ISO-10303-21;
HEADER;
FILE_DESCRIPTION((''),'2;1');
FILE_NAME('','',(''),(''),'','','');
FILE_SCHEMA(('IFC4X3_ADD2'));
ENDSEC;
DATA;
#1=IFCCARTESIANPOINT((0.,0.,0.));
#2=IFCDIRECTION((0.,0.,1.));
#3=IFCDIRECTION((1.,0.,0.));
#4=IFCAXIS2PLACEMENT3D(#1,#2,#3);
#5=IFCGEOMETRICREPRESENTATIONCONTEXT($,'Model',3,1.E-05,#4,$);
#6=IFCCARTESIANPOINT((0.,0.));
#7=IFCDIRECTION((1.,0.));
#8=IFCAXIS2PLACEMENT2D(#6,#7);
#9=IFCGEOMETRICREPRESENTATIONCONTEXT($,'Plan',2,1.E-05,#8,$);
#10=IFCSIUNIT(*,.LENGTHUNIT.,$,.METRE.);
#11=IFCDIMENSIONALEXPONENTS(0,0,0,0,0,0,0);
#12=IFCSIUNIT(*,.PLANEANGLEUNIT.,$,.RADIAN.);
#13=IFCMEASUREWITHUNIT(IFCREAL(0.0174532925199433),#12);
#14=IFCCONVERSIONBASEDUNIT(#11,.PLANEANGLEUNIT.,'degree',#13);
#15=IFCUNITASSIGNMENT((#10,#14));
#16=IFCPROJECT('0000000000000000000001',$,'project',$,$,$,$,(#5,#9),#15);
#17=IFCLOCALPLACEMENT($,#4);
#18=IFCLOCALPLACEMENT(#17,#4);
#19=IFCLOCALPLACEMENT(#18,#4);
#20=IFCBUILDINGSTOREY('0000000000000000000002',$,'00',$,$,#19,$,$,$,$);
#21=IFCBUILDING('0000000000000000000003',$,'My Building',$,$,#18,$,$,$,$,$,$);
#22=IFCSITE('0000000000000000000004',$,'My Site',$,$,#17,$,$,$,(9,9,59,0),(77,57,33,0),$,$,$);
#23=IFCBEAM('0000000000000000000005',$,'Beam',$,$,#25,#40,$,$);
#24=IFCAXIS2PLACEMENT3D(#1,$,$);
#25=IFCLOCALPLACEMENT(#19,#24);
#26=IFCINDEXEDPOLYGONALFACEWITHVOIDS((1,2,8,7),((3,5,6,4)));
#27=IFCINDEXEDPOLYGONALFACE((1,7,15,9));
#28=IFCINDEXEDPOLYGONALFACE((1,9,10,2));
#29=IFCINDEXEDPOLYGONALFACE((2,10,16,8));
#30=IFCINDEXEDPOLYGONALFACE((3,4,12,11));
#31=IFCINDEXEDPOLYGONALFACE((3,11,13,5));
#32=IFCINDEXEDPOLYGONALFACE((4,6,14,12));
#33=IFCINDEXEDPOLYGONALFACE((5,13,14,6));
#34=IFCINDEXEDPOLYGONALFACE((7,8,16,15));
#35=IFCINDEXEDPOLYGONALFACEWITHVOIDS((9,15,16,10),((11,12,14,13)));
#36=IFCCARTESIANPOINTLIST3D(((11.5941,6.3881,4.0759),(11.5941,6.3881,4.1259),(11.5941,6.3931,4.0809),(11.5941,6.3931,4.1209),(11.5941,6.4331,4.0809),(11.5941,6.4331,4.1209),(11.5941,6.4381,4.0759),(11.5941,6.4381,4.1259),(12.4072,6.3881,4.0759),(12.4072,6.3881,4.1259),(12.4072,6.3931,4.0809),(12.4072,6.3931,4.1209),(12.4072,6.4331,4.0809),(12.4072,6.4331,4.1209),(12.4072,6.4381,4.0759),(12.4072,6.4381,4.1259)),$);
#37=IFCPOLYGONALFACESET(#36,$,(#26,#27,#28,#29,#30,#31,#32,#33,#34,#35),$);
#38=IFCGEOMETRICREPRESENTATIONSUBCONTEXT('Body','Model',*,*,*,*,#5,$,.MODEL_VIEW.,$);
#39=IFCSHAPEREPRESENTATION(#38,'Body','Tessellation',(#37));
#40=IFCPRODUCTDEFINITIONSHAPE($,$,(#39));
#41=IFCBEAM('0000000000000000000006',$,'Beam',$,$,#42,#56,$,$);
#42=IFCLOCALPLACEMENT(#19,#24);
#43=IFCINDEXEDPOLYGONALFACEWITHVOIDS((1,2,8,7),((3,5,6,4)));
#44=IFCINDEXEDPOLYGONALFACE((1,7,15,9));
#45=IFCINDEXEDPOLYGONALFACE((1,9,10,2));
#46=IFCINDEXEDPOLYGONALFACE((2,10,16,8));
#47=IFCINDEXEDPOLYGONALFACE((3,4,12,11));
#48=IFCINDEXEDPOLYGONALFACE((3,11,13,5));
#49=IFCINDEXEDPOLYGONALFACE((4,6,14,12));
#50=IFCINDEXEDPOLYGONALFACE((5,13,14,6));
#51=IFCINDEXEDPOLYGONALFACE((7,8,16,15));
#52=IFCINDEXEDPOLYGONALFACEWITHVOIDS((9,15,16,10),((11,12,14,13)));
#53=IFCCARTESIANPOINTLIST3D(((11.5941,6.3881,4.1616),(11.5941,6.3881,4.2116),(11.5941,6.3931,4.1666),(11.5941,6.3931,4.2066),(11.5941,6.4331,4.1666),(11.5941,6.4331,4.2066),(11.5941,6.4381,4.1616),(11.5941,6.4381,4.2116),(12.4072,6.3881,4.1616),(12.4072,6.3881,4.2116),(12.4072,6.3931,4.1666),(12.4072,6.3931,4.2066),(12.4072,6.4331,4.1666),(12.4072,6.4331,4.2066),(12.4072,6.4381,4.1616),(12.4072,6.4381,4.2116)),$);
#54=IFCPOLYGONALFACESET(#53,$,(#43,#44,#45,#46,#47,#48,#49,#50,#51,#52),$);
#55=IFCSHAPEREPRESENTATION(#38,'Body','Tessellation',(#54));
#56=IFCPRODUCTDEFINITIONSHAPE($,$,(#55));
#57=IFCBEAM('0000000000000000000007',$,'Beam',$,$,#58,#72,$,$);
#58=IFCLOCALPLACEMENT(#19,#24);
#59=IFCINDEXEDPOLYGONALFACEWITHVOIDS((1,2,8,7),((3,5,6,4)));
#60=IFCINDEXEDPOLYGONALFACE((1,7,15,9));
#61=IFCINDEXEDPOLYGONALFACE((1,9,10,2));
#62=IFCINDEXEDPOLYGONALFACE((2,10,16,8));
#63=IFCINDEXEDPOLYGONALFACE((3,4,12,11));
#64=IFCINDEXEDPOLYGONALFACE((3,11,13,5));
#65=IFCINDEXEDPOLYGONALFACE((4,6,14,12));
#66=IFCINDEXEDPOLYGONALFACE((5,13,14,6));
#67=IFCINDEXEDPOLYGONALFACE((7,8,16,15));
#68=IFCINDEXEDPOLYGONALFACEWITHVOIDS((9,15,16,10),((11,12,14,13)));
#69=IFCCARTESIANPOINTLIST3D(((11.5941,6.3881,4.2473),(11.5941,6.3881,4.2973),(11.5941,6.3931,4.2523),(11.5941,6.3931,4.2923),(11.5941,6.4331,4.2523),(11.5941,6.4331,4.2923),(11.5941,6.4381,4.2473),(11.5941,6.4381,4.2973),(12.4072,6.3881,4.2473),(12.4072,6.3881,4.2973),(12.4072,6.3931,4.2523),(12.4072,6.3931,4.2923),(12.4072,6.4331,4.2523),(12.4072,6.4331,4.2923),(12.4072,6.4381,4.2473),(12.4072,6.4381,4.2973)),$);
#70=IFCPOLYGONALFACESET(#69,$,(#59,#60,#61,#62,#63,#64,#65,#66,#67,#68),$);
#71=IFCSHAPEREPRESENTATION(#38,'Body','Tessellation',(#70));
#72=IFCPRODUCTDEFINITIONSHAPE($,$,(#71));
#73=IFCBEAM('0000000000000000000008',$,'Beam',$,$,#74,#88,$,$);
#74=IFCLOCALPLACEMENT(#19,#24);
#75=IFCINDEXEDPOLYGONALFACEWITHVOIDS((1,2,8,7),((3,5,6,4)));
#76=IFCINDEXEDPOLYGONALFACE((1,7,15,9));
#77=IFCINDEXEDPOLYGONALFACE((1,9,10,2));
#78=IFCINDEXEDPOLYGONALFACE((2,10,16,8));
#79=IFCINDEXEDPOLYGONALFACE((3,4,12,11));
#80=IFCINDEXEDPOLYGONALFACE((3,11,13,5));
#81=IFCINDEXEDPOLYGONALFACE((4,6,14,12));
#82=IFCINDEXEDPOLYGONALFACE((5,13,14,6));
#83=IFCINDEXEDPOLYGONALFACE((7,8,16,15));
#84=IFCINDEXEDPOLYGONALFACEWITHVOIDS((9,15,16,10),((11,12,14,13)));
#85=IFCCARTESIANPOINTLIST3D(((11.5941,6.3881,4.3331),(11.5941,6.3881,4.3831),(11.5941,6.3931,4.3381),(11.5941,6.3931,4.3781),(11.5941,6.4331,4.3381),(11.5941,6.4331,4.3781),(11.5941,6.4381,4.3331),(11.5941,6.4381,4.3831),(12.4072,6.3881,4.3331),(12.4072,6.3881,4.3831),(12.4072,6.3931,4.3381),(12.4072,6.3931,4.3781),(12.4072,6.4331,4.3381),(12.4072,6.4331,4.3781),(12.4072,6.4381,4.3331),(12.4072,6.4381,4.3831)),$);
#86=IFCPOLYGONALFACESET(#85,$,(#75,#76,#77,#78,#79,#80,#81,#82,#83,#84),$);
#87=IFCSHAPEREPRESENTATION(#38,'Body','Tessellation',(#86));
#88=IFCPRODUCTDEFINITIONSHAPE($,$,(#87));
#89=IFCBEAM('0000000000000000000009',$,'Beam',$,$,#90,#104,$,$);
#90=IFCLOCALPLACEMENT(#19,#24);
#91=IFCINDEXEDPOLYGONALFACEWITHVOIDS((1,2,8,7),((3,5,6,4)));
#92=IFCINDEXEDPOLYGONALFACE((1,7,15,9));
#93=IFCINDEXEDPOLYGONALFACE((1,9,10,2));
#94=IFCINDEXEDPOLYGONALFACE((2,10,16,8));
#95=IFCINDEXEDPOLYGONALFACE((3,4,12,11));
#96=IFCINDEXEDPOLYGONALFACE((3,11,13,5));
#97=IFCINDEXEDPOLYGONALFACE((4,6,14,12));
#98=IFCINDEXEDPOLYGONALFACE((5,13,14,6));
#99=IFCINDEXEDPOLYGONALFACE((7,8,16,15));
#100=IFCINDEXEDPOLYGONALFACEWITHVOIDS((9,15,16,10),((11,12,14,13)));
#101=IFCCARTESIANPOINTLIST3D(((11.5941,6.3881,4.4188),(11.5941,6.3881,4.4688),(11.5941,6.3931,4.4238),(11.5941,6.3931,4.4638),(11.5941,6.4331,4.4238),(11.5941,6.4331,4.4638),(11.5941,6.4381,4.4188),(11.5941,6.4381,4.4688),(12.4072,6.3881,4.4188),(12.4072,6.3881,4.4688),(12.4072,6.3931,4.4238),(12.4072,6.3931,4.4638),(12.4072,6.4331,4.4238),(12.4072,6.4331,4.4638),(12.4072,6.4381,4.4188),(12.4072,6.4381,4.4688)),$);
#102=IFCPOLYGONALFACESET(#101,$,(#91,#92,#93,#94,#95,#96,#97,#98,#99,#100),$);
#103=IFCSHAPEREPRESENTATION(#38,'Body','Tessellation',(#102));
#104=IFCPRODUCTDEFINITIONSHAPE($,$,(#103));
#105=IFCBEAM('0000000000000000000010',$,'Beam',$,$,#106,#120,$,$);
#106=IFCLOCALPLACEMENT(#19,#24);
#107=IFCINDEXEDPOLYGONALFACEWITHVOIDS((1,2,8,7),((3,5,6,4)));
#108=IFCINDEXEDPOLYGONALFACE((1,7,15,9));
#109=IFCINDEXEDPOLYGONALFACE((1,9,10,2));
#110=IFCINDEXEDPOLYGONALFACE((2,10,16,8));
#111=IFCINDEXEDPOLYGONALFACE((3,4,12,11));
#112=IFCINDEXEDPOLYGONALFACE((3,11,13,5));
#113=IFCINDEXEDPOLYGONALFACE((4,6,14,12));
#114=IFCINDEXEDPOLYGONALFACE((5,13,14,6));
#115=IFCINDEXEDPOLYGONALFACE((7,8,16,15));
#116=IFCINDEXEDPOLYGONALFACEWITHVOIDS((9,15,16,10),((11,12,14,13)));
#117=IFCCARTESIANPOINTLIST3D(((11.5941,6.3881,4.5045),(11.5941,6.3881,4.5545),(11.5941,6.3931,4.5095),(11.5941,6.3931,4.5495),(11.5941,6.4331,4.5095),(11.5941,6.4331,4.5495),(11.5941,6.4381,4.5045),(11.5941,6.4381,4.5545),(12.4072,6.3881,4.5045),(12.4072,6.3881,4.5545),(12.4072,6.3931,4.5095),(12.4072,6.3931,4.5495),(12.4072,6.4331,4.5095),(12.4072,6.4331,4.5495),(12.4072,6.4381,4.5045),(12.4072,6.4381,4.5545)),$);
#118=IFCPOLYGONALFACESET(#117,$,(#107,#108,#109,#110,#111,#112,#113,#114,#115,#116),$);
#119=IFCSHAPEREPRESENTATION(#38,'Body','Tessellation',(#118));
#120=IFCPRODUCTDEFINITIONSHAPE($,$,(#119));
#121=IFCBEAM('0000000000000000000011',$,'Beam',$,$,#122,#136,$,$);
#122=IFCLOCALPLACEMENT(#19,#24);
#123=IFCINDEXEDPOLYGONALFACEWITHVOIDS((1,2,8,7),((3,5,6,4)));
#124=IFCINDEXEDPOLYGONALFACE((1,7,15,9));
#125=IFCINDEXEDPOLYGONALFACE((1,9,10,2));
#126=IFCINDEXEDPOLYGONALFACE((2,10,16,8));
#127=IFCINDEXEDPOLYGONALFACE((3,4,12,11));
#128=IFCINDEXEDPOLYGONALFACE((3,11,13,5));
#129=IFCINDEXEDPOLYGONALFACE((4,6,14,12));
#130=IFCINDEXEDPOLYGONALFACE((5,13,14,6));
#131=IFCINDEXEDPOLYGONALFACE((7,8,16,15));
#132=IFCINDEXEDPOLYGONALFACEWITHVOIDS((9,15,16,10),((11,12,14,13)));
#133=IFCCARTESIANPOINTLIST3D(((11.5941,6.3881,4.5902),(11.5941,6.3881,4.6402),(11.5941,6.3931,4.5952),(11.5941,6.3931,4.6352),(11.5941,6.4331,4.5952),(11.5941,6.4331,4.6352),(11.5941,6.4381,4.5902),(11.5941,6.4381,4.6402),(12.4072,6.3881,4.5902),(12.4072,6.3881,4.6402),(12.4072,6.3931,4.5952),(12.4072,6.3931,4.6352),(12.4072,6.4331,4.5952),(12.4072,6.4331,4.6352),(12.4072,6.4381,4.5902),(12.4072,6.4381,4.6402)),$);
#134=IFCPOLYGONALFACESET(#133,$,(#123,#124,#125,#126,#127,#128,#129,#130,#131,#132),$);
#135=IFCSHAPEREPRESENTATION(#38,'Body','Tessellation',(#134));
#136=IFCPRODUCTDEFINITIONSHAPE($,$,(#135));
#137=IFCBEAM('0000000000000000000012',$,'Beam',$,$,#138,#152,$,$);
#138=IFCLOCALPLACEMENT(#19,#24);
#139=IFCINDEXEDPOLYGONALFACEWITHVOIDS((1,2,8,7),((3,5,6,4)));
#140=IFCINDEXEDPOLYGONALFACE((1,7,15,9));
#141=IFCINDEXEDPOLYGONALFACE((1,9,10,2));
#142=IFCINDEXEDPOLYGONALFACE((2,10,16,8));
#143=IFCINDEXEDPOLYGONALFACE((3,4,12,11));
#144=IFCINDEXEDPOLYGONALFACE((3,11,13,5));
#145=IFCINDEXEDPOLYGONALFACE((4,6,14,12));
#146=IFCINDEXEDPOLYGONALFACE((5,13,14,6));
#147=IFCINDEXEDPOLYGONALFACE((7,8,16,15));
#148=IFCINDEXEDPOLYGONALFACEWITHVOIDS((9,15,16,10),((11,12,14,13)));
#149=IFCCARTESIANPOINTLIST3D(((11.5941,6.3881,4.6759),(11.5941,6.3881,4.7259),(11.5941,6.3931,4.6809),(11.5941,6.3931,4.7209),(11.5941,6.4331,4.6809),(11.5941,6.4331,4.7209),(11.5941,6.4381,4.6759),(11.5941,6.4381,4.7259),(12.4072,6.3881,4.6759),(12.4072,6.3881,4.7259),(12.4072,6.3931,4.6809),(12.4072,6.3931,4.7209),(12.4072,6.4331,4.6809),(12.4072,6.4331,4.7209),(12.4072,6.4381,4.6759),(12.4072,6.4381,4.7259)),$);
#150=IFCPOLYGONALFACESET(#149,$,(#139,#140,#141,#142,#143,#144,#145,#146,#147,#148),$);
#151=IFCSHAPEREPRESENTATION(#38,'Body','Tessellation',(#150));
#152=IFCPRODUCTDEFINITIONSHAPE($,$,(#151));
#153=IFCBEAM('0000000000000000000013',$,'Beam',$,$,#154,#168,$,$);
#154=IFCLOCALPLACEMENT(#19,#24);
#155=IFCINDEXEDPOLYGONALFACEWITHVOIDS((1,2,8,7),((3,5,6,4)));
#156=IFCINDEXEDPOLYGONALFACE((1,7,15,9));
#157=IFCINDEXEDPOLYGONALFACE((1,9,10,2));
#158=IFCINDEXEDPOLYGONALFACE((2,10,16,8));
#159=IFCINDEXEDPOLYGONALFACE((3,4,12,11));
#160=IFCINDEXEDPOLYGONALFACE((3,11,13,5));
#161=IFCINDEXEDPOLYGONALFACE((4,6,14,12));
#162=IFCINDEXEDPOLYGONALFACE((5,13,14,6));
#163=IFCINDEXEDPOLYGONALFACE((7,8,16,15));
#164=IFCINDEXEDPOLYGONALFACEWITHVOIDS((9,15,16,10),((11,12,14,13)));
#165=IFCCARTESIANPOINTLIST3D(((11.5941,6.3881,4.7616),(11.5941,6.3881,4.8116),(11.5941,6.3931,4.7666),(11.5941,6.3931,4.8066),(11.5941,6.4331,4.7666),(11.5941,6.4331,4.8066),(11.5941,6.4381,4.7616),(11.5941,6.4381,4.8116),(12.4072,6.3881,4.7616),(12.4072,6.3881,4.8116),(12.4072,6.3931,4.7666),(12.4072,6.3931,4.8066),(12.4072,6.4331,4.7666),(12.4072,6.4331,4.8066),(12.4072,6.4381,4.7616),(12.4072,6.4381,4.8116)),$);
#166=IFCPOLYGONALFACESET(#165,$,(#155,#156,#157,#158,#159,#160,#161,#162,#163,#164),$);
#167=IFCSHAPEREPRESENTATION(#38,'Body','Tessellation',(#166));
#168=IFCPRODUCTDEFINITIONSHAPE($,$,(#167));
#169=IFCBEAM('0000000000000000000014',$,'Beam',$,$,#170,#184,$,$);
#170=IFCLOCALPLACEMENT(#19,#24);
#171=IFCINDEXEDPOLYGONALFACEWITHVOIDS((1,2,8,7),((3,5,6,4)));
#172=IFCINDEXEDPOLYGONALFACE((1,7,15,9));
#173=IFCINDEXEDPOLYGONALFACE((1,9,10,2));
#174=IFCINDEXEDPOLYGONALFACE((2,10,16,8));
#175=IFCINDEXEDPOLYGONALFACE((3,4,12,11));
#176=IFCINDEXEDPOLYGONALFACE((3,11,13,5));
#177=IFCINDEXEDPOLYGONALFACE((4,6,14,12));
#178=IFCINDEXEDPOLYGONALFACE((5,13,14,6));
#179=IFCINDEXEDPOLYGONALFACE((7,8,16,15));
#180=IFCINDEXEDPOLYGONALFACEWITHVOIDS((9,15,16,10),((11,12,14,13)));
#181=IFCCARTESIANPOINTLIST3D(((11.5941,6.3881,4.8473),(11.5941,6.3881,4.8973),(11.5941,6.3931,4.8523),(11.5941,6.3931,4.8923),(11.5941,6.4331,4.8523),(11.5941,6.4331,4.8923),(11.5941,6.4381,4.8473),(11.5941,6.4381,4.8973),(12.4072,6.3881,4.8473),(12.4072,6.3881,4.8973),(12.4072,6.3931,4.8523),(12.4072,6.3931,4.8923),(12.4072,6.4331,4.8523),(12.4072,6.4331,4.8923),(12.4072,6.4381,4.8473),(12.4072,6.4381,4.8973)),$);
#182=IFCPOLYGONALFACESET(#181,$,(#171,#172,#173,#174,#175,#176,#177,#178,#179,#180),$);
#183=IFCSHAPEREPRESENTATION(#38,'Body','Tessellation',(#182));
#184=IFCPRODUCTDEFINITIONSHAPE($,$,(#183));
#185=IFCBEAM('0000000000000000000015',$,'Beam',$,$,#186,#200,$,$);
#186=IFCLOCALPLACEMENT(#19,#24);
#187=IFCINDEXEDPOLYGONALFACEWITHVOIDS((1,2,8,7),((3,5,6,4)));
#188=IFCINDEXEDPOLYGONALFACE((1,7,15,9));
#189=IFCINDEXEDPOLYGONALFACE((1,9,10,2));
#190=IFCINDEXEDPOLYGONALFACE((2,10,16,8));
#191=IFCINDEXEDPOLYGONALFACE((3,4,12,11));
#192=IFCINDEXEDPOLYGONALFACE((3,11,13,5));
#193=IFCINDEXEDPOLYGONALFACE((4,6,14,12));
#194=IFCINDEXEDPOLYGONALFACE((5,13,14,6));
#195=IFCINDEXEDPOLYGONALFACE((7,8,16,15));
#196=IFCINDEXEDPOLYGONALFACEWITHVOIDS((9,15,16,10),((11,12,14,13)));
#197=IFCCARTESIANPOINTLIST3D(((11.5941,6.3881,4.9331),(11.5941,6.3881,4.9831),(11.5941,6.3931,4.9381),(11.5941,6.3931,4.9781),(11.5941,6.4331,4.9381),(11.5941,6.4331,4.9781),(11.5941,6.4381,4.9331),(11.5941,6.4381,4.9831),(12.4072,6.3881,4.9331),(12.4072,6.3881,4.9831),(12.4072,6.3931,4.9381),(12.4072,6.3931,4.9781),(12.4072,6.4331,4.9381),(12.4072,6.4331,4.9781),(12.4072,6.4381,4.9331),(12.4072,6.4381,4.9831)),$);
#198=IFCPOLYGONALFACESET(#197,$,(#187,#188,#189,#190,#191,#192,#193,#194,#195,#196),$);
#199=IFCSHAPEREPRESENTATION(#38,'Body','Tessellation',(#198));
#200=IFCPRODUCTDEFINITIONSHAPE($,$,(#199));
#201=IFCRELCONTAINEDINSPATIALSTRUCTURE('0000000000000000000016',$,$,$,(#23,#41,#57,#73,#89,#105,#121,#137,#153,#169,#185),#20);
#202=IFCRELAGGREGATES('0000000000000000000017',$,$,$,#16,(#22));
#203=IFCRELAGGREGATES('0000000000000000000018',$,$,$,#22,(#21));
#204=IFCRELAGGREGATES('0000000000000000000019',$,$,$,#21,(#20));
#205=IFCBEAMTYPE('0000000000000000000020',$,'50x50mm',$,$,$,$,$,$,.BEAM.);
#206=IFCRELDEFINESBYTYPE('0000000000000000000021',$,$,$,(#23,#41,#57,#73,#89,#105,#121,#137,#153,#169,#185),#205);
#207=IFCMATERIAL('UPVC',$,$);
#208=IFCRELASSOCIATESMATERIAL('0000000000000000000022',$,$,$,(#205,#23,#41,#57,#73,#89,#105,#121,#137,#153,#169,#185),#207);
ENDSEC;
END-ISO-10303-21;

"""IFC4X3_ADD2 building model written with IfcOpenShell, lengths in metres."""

from ifc_helpers import new_model, entity, si_unit, converted_unit, frame, origin_with_axes, origin_2d_with_axis, place, context, subcontext, project, spatial, hollow_rectangle, extrude, material, material_profile, profile_set, profile_usage, type_object, element, save


model = new_model("IFC4X3_ADD2")

# Units and contexts
model_context = context("Model", 3, precision=1e-05, world=origin_with_axes())
plan_context = context("Plan", 2, precision=1e-05, world=origin_2d_with_axis())
body_context = subcontext(model_context, "Body", "Model", "MODEL_VIEW")
ifc_project = project(units=[si_unit("LENGTHUNIT", "METRE"), converted_unit("PLANEANGLEUNIT", "degree", entity("IfcReal", 0.0174532925199433), si_unit("PLANEANGLEUNIT", "RADIAN"), dimensions=[0, 0, 0, 0, 0, 0, 0])], contexts=[model_context, plan_context])

# Site, building, storey
site_placement = place(None, origin_with_axes())
site = spatial("IfcSite", under=ifc_project, at=site_placement, Name="My Site", RefLatitude=(9, 9, 59, 0), RefLongitude=(77, 57, 33, 0))
building_placement = place(site_placement, origin_with_axes())
building = spatial("IfcBuilding", under=site, at=building_placement, Name="My Building")
storey_placement = place(building_placement, origin_with_axes())
storey = spatial("IfcBuildingStorey", under=building, at=storey_placement, Name="00")

# Shared definitions
ifc_material_1 = material(Name="UPVC")

# Beams
ifc_material_profile_1 = material_profile(ifc_material_1, hollow_rectangle(XDim=0.05, YDim=0.05, WallThickness=0.005))
ifc_profile_set_1 = profile_set([ifc_material_profile_1])
beam_type = type_object("IfcBeamType", Name="50x50mm", PredefinedType="BEAM", material=ifc_profile_set_1)
ifc_profile_usage_1 = profile_usage(ifc_profile_set_1, cardinal=5)
beam_1_placement = place(storey_placement, frame((11.5941, 6.4131, 4.1009), z_axis=(1.0, 0.0, 0.000001), x_axis=(0.0, 1.0, 0.0)))
element("IfcBeam", 1, at=beam_1_placement, inside=storey, type_object=beam_type, material=ifc_profile_usage_1, Name="Beam", context=body_context, shape_type="SweptSolid", body=[
    extrude(hollow_rectangle(XDim=0.05, YDim=0.05, WallThickness=0.005), origin_with_axes(), (0.0, 0.0, 1.0), 0.8131),
])
ifc_profile_usage_2 = profile_usage(ifc_profile_set_1, cardinal=5)
beam_2_placement = place(storey_placement, frame((11.5941, 6.4131, 4.1866), z_axis=(1.0, 0.0, 0.000001), x_axis=(0.0, 1.0, 0.0)))
element("IfcBeam", 2, at=beam_2_placement, inside=storey, type_object=beam_type, material=ifc_profile_usage_2, Name="Beam", context=body_context, shape_type="SweptSolid", body=[
    extrude(hollow_rectangle(XDim=0.05, YDim=0.05, WallThickness=0.005), origin_with_axes(), (0.0, 0.0, 1.0), 0.8131),
])
ifc_profile_usage_3 = profile_usage(ifc_profile_set_1, cardinal=5)
beam_3_placement = place(storey_placement, frame((11.5941, 6.4131, 4.2723), z_axis=(1.0, 0.0, 0.000001), x_axis=(0.0, 1.0, 0.0)))
element("IfcBeam", 3, at=beam_3_placement, inside=storey, type_object=beam_type, material=ifc_profile_usage_3, Name="Beam", context=body_context, shape_type="SweptSolid", body=[
    extrude(hollow_rectangle(XDim=0.05, YDim=0.05, WallThickness=0.005), origin_with_axes(), (0.0, 0.0, 1.0), 0.8131),
])
ifc_profile_usage_4 = profile_usage(ifc_profile_set_1, cardinal=5)
beam_4_placement = place(storey_placement, frame((11.5941, 6.4131, 4.3581), z_axis=(1.0, 0.0, 0.000001), x_axis=(0.0, 1.0, 0.0)))
element("IfcBeam", 4, at=beam_4_placement, inside=storey, type_object=beam_type, material=ifc_profile_usage_4, Name="Beam", context=body_context, shape_type="SweptSolid", body=[
    extrude(hollow_rectangle(XDim=0.05, YDim=0.05, WallThickness=0.005), origin_with_axes(), (0.0, 0.0, 1.0), 0.8131),
])
ifc_profile_usage_5 = profile_usage(ifc_profile_set_1, cardinal=5)
beam_5_placement = place(storey_placement, frame((11.5941, 6.4131, 4.4438), z_axis=(1.0, 0.0, 0.000001), x_axis=(0.0, 1.0, 0.0)))
element("IfcBeam", 5, at=beam_5_placement, inside=storey, type_object=beam_type, material=ifc_profile_usage_5, Name="Beam", context=body_context, shape_type="SweptSolid", body=[
    extrude(hollow_rectangle(XDim=0.05, YDim=0.05, WallThickness=0.005), origin_with_axes(), (0.0, 0.0, 1.0), 0.8131),
])
ifc_profile_usage_6 = profile_usage(ifc_profile_set_1, cardinal=5)
beam_6_placement = place(storey_placement, frame((11.5941, 6.4131, 4.5295), z_axis=(1.0, 0.0, 0.000001), x_axis=(0.0, 1.0, 0.0)))
element("IfcBeam", 6, at=beam_6_placement, inside=storey, type_object=beam_type, material=ifc_profile_usage_6, Name="Beam", context=body_context, shape_type="SweptSolid", body=[
    extrude(hollow_rectangle(XDim=0.05, YDim=0.05, WallThickness=0.005), origin_with_axes(), (0.0, 0.0, 1.0), 0.8131),
])
ifc_profile_usage_7 = profile_usage(ifc_profile_set_1, cardinal=5)
beam_7_placement = place(storey_placement, frame((11.5941, 6.4131, 4.6152), z_axis=(1.0, 0.0, 0.000001), x_axis=(0.0, 1.0, 0.0)))
element("IfcBeam", 7, at=beam_7_placement, inside=storey, type_object=beam_type, material=ifc_profile_usage_7, Name="Beam", context=body_context, shape_type="SweptSolid", body=[
    extrude(hollow_rectangle(XDim=0.05, YDim=0.05, WallThickness=0.005), origin_with_axes(), (0.0, 0.0, 1.0), 0.8131),
])
ifc_profile_usage_8 = profile_usage(ifc_profile_set_1, cardinal=5)
beam_8_placement = place(storey_placement, frame((11.5941, 6.4131, 4.7009), z_axis=(1.0, 0.0, 0.000001), x_axis=(0.0, 1.0, 0.0)))
element("IfcBeam", 8, at=beam_8_placement, inside=storey, type_object=beam_type, material=ifc_profile_usage_8, Name="Beam", context=body_context, shape_type="SweptSolid", body=[
    extrude(hollow_rectangle(XDim=0.05, YDim=0.05, WallThickness=0.005), origin_with_axes(), (0.0, 0.0, 1.0), 0.8131),
])
ifc_profile_usage_9 = profile_usage(ifc_profile_set_1, cardinal=5)
beam_9_placement = place(storey_placement, frame((11.5941, 6.4131, 4.7866), z_axis=(1.0, 0.0, 0.000001), x_axis=(0.0, 1.0, 0.0)))
element("IfcBeam", 9, at=beam_9_placement, inside=storey, type_object=beam_type, material=ifc_profile_usage_9, Name="Beam", context=body_context, shape_type="SweptSolid", body=[
    extrude(hollow_rectangle(XDim=0.05, YDim=0.05, WallThickness=0.005), origin_with_axes(), (0.0, 0.0, 1.0), 0.8131),
])
ifc_profile_usage_10 = profile_usage(ifc_profile_set_1, cardinal=5)
beam_10_placement = place(storey_placement, frame((11.5941, 6.4131, 4.8723), z_axis=(1.0, 0.0, 0.000001), x_axis=(0.0, 1.0, 0.0)))
element("IfcBeam", 10, at=beam_10_placement, inside=storey, type_object=beam_type, material=ifc_profile_usage_10, Name="Beam", context=body_context, shape_type="SweptSolid", body=[
    extrude(hollow_rectangle(XDim=0.05, YDim=0.05, WallThickness=0.005), origin_with_axes(), (0.0, 0.0, 1.0), 0.8131),
])
ifc_profile_usage_11 = profile_usage(ifc_profile_set_1, cardinal=5)
beam_11_placement = place(storey_placement, frame((11.5941, 6.4131, 4.9581), z_axis=(1.0, 0.0, 0.000001), x_axis=(0.0, 1.0, 0.0)))
element("IfcBeam", 11, at=beam_11_placement, inside=storey, type_object=beam_type, material=ifc_profile_usage_11, Name="Beam", context=body_context, shape_type="SweptSolid", body=[
    extrude(hollow_rectangle(XDim=0.05, YDim=0.05, WallThickness=0.005), origin_with_axes(), (0.0, 0.0, 1.0), 0.8131),
])

save(model, "model.ifc")
